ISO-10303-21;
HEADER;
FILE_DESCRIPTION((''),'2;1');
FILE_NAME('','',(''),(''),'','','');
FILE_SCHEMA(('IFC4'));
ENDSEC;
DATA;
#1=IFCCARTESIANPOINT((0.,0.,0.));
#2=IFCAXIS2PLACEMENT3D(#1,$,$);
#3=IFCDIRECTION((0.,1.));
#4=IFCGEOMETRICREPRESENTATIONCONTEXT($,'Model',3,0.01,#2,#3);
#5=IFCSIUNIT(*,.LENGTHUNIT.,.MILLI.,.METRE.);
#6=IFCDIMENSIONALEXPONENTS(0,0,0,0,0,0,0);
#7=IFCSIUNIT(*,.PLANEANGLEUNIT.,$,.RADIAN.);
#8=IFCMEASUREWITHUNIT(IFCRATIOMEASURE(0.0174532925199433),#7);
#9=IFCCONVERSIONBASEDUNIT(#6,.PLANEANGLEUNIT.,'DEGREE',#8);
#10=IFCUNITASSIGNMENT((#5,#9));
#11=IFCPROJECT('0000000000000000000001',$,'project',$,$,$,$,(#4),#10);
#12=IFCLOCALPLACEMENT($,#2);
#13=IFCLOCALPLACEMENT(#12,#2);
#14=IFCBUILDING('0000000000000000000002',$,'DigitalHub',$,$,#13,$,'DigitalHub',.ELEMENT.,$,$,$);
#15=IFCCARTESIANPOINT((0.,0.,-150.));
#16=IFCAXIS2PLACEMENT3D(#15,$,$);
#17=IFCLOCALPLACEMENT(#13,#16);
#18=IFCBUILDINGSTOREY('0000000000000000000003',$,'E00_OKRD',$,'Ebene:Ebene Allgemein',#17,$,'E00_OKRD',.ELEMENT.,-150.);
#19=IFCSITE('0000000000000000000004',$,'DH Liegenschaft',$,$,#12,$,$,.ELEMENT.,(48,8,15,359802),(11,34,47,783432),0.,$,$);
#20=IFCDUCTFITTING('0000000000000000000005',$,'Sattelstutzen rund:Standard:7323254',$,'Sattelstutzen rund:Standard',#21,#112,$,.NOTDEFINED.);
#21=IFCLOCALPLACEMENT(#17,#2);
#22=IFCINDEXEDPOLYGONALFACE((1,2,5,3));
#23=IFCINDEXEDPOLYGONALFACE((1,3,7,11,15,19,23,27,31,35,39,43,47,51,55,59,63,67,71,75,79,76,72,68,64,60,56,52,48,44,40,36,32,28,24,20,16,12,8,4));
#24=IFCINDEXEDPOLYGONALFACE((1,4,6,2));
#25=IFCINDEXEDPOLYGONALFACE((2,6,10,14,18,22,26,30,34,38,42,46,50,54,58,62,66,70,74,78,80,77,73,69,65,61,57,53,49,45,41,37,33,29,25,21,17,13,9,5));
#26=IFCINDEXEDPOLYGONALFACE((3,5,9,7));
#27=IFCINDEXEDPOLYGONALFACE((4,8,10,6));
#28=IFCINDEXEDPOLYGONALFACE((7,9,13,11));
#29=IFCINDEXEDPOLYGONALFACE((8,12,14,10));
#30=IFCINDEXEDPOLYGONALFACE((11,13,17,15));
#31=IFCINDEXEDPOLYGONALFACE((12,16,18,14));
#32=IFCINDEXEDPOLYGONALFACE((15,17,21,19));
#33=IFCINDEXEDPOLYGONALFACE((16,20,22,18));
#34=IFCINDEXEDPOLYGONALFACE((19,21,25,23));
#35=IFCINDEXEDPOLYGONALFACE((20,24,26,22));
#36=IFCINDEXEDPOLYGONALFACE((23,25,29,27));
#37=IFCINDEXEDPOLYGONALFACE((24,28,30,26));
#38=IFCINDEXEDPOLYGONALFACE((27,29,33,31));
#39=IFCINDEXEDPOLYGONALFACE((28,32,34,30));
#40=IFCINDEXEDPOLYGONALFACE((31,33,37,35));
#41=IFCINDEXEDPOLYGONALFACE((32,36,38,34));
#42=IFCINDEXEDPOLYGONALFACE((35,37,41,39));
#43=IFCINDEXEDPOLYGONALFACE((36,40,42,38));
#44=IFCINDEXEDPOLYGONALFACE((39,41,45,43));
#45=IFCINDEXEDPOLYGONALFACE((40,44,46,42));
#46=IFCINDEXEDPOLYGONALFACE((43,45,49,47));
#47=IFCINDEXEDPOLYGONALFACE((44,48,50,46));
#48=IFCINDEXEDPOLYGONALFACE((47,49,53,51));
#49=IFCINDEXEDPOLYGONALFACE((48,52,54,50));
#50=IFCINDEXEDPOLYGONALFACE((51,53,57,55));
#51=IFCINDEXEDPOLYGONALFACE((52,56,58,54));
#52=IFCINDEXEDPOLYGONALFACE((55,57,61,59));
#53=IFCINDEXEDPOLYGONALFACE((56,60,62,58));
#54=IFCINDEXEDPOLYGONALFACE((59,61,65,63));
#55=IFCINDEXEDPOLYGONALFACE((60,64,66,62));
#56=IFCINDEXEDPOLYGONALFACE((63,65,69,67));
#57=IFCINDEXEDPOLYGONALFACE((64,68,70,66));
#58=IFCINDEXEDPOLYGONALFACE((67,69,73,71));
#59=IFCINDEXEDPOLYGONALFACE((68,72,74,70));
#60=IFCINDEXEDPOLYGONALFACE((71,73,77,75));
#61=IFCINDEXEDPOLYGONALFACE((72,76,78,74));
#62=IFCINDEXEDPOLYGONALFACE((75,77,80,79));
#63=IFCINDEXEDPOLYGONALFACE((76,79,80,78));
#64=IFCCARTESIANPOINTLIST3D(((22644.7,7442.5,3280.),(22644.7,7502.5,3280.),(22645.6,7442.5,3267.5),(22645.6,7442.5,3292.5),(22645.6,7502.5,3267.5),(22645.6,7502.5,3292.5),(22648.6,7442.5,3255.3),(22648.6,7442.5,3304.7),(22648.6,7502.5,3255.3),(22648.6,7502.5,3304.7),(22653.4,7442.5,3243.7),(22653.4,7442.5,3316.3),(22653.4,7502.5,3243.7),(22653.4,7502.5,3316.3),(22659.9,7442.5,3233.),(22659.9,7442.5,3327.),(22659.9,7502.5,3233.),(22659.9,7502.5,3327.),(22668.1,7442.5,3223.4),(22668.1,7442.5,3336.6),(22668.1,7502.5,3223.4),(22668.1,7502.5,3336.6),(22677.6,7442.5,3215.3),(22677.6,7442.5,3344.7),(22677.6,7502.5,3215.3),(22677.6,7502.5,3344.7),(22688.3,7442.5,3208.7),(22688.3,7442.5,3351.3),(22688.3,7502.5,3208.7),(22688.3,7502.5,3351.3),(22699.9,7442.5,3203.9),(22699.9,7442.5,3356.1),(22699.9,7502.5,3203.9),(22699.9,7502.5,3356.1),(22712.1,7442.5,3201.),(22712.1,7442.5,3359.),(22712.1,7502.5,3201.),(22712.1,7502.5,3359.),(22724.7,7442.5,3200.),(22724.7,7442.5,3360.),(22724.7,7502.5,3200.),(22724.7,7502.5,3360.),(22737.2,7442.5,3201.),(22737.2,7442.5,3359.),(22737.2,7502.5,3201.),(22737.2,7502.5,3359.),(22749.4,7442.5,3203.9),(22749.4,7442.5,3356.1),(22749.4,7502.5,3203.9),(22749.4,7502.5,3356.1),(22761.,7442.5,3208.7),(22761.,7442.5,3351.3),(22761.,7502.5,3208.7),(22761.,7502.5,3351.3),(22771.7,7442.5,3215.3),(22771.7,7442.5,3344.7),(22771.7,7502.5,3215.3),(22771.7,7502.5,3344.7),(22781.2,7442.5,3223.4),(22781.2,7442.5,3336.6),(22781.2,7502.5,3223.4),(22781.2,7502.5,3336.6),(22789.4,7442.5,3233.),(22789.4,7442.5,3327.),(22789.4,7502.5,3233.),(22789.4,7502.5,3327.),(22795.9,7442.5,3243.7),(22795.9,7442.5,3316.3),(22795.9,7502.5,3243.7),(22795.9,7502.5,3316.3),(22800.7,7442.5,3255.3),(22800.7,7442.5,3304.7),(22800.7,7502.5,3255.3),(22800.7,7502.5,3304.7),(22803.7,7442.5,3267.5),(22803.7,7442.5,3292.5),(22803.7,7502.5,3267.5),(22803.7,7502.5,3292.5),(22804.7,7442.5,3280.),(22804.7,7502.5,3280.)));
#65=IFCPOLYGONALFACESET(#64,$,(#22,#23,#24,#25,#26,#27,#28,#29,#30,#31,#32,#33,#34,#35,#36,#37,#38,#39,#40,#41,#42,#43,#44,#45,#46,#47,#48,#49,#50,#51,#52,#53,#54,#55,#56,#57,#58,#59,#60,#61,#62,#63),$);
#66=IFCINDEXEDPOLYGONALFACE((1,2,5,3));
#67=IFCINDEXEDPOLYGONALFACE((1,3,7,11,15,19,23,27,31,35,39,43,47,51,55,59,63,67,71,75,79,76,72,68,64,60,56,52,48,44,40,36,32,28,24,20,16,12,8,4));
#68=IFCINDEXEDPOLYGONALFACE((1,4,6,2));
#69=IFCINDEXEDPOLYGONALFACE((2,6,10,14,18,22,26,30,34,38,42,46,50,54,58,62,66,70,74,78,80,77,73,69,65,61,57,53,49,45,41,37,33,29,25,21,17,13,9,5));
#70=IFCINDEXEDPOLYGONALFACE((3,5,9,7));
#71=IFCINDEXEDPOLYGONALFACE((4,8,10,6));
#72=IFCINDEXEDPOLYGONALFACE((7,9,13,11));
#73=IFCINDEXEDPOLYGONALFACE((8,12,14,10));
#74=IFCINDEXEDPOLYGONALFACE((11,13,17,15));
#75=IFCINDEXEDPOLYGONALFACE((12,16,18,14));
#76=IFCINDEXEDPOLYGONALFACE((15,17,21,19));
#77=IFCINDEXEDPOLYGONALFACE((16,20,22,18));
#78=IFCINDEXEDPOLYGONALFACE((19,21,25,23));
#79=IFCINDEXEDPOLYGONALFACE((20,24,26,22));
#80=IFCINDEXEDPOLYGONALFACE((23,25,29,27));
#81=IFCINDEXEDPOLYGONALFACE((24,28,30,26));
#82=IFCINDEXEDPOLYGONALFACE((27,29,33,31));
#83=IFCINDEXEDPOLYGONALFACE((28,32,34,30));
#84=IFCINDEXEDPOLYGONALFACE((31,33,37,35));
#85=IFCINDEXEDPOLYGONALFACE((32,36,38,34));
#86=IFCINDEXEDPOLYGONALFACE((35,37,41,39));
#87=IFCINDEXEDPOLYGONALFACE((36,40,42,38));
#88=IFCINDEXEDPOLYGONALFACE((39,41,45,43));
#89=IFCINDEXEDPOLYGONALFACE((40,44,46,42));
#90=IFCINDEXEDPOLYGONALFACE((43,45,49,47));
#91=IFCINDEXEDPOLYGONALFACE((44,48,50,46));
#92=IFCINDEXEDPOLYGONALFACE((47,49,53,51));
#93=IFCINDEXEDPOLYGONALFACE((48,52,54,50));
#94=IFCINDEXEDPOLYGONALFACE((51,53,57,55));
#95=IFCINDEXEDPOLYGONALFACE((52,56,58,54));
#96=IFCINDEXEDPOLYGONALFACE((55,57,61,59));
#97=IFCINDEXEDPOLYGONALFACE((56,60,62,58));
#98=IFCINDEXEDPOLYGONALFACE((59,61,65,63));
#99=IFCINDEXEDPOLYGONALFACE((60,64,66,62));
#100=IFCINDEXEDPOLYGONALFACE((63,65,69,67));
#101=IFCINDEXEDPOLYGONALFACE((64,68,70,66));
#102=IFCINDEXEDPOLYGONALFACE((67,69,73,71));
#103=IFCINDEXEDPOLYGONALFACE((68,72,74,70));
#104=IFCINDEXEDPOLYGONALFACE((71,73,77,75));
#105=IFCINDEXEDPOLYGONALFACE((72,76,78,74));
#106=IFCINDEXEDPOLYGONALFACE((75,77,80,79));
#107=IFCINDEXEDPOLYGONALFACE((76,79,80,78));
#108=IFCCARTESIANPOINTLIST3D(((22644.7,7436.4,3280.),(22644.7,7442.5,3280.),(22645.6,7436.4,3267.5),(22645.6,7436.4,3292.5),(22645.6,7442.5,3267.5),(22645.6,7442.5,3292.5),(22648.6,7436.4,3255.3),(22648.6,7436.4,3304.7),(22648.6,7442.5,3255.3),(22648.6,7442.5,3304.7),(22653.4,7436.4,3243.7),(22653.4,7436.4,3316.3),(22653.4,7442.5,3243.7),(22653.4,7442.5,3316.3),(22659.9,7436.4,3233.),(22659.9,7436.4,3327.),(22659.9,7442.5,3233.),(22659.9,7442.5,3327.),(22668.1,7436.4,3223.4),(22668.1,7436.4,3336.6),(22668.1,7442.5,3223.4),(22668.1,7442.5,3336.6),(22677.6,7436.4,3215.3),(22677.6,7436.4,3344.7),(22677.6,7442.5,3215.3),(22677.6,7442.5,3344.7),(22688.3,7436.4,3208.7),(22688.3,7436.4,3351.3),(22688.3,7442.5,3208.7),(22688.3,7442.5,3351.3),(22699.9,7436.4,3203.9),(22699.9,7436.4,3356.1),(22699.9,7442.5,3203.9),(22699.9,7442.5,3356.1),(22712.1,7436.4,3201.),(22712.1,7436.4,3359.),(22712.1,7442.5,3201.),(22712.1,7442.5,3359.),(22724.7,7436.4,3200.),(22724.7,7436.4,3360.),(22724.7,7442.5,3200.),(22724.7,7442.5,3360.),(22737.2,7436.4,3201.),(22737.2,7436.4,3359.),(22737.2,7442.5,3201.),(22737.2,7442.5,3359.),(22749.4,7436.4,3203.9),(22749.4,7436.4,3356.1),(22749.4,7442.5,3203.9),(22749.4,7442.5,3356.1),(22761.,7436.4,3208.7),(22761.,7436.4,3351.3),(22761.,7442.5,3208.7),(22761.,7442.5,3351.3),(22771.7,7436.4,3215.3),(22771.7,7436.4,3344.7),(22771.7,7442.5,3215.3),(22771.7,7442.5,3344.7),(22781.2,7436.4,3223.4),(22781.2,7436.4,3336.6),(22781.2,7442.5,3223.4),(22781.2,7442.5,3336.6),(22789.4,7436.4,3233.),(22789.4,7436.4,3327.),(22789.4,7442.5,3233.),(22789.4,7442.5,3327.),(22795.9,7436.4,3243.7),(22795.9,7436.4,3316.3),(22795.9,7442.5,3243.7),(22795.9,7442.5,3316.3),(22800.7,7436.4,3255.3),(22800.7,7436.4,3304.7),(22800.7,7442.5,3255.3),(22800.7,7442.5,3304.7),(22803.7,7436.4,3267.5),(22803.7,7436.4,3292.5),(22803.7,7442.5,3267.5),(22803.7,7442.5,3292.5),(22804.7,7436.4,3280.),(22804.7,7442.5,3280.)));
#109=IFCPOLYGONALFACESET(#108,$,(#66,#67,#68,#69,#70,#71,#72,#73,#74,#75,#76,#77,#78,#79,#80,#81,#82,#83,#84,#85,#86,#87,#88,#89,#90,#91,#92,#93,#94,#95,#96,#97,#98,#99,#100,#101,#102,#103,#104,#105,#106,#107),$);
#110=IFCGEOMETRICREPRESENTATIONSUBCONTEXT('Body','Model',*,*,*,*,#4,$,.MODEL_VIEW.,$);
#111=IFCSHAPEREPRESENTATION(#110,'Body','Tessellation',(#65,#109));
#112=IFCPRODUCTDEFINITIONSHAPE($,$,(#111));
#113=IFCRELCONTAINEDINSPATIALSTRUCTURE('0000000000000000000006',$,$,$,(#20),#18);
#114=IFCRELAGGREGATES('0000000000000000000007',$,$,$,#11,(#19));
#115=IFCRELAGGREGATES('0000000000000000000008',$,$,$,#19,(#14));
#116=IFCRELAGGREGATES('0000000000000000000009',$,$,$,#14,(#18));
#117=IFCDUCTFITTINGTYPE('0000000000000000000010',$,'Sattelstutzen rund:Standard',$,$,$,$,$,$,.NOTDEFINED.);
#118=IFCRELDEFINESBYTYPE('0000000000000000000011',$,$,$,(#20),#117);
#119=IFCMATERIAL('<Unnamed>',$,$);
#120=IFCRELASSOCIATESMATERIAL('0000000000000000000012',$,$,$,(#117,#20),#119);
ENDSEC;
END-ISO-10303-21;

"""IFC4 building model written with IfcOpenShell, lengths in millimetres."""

from ifc_helpers import new_model, entity, si_unit, converted_unit, direction, frame, origin, place, context, subcontext, project, spatial, indexed_curve, outline, extrude, source, transform, mapped, material, type_object, type_shapes, element, save


model = new_model("IFC4")

# Units and contexts
model_context = context("Model", 3, precision=0.01, world=origin(), true_north=direction((0.0, 1.0)))
body_context = subcontext(model_context, "Body", "Model", "MODEL_VIEW")
ifc_project = project(units=[si_unit("LENGTHUNIT", "METRE", prefix="MILLI"), converted_unit("PLANEANGLEUNIT", "DEGREE", entity("IfcRatioMeasure", 0.0174532925199433), si_unit("PLANEANGLEUNIT", "RADIAN"), dimensions=[0, 0, 0, 0, 0, 0, 0])], contexts=[model_context])

# Site, building, storey
site_placement = place(None, origin())
site = spatial("IfcSite", under=ifc_project, at=site_placement, Name="DH Liegenschaft", CompositionType="ELEMENT", RefLatitude=(48, 8, 15, 359802), RefLongitude=(11, 34, 47, 783432), RefElevation=0.0)
building_placement = place(site_placement, origin())
building = spatial("IfcBuilding", under=site, at=building_placement, Name="DigitalHub", LongName="DigitalHub", CompositionType="ELEMENT")
storey_placement = place(building_placement, frame((0.0, 0.0, -150.0)))
storey = spatial("IfcBuildingStorey", under=building, at=storey_placement, Name="E00_OKRD", ObjectType="Ebene:Ebene Allgemein", LongName="E00_OKRD", CompositionType="ELEMENT", Elevation=-150.0)

# Shared definitions
ifc_material_1 = material(Name="<Unnamed>")

# Duct fitting
duct_fitting_type_1 = type_object("IfcDuctFittingType", Name="Sattelstutzen rund:Standard", PredefinedType="NOTDEFINED", material=ifc_material_1)
shared_shape_1 = source(origin(), body_context, "Body", "SweptSolid", [
    extrude(outline(indexed_curve([(0.0, 80.0), (-12.5, 79.0), (-24.7, 76.1), (-36.3, 71.3), (-47.0, 64.7), (-56.6, 56.6), (-64.7, 47.0), (-71.3, 36.3), (-76.1, 24.7), (-79.0, 12.5), (-80.0, 0.0), (-79.0, -12.5), (-76.1, -24.7), (-71.3, -36.3), (-64.7, -47.0), (-56.6, -56.6), (-47.0, -64.7), (-36.3, -71.3), (-24.7, -76.1), (-12.5, -79.0), (0.0, -80.0), (12.5, -79.0), (24.7, -76.1), (36.3, -71.3), (47.0, -64.7), (56.6, -56.6), (64.7, -47.0), (71.3, -36.3), (76.1, -24.7), (79.0, -12.5), (80.0, 0.0), (79.0, 12.5), (76.1, 24.7), (71.3, 36.3), (64.7, 47.0), (56.6, 56.6), (47.0, 64.7), (36.3, 71.3), (24.7, 76.1), (12.5, 79.0), (0.0, 80.0)], self_intersect=False)), frame((0.0, 0.0, 0.0), z_axis=(1.0, 0.0, 0.0), x_axis=(0.0, 1.0, 0.0)), (0.0, 0.0, 1.0), 60.0),
    extrude(outline(indexed_curve([(0.0, 80.0), (-12.5, 79.0), (-24.7, 76.1), (-36.3, 71.3), (-47.0, 64.7), (-56.6, 56.6), (-64.7, 47.0), (-71.3, 36.3), (-76.1, 24.7), (-79.0, 12.5), (-80.0, 0.0), (-79.0, -12.5), (-76.1, -24.7), (-71.3, -36.3), (-64.7, -47.0), (-56.6, -56.6), (-47.0, -64.7), (-36.3, -71.3), (-24.7, -76.1), (-12.5, -79.0), (0.0, -80.0), (12.5, -79.0), (24.7, -76.1), (36.3, -71.3), (47.0, -64.7), (56.6, -56.6), (64.7, -47.0), (71.3, -36.3), (76.1, -24.7), (79.0, -12.5), (80.0, 0.0), (79.0, 12.5), (76.1, 24.7), (71.3, 36.3), (64.7, 47.0), (56.6, 56.6), (47.0, 64.7), (36.3, 71.3), (24.7, 76.1), (12.5, 79.0), (0.0, 80.0)], self_intersect=False)), frame((-6.1, 0.0, 0.0), z_axis=(1.0, 0.0, 0.0), x_axis=(0.0, 1.0, 0.0)), (0.0, 0.0, 1.0), 6.1),
])
type_shapes(duct_fitting_type_1, [shared_shape_1])
for number, where, z_axis, x_axis, name in (
    (1, (22724.7, 7442.5, 3280.0), (0.0, 0.0, -1.0), (0.0, 1.0, 0.0), "Sattelstutzen rund:Standard:7323254"),
):
    element("IfcDuctFitting", number, at=place(storey_placement, frame(where, z_axis=z_axis, x_axis=x_axis)), inside=storey, type_object=duct_fitting_type_1, material=ifc_material_1, Name=name, ObjectType="Sattelstutzen rund:Standard", PredefinedType="NOTDEFINED", context=body_context, shape_type="MappedRepresentation", body=[
        mapped(shared_shape_1, transform((0.0, 0.0, 0.0), scale=1.0)),
    ])

save(model, "model.ifc")
